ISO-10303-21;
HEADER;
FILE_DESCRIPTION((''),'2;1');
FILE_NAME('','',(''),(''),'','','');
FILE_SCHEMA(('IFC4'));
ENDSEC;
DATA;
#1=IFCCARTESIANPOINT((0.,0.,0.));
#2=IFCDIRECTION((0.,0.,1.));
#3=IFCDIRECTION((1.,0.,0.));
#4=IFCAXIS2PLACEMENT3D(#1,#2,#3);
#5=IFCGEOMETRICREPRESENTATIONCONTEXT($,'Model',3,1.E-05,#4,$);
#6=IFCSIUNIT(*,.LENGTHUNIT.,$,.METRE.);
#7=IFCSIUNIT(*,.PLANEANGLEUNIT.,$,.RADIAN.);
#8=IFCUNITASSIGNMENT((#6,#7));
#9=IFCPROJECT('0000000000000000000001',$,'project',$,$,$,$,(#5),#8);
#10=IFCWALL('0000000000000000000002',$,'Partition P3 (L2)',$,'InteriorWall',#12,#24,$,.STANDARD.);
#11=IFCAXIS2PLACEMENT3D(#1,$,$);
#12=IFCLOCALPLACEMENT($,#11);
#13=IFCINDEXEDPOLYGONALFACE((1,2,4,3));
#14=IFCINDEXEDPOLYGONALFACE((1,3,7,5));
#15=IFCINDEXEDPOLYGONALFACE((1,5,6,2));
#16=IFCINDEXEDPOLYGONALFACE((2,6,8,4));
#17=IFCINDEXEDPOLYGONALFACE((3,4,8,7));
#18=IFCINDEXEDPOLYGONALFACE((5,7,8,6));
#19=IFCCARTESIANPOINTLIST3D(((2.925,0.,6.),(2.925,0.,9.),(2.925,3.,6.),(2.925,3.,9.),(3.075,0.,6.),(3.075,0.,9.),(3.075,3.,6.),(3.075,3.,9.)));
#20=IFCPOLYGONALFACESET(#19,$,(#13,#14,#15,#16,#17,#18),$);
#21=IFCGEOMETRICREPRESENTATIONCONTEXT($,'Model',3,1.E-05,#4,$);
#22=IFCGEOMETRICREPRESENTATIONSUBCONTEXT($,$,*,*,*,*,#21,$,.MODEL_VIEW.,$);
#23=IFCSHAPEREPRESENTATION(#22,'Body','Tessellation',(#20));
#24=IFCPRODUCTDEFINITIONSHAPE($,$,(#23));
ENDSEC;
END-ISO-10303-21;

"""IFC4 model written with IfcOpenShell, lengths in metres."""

from ifc_helpers import new_model, si_unit, frame, frame_2d, origin, origin_with_axes, place, context, subcontext, project, rectangle, extrude, element, save


model = new_model("IFC4")

# Units and contexts
model_context_1 = context("Model", 3, precision=1e-05, world=origin_with_axes())
model_context_2 = context("Model", 3, precision=1e-05, world=origin_with_axes())
sub_context = subcontext(model_context_2, None, None, "MODEL_VIEW")
ifc_project = project(units=[si_unit("LENGTHUNIT", "METRE"), si_unit("PLANEANGLEUNIT", "RADIAN")], contexts=[model_context_1])

# Wall
placement_1 = place(None, origin_with_axes())
placement_2 = place(placement_1, frame((0.0, 0.0, 3.0)))
wall_placement = place(placement_2, frame((3.0, 0.0, 3.0), x_axis=(0.0, 1.0, 0.0)))
element("IfcWall", 1, at=wall_placement, Name="Partition P3 (L2)", ObjectType="InteriorWall", PredefinedType="STANDARD", context=sub_context, shape_type="SweptSolid", body=[
    extrude(rectangle(XDim=3.0, YDim=0.15, at=frame_2d((1.5, 0.0))), origin(), (0.0, 0.0, 1.0), 3.0),
])

save(model, "model.ifc")
